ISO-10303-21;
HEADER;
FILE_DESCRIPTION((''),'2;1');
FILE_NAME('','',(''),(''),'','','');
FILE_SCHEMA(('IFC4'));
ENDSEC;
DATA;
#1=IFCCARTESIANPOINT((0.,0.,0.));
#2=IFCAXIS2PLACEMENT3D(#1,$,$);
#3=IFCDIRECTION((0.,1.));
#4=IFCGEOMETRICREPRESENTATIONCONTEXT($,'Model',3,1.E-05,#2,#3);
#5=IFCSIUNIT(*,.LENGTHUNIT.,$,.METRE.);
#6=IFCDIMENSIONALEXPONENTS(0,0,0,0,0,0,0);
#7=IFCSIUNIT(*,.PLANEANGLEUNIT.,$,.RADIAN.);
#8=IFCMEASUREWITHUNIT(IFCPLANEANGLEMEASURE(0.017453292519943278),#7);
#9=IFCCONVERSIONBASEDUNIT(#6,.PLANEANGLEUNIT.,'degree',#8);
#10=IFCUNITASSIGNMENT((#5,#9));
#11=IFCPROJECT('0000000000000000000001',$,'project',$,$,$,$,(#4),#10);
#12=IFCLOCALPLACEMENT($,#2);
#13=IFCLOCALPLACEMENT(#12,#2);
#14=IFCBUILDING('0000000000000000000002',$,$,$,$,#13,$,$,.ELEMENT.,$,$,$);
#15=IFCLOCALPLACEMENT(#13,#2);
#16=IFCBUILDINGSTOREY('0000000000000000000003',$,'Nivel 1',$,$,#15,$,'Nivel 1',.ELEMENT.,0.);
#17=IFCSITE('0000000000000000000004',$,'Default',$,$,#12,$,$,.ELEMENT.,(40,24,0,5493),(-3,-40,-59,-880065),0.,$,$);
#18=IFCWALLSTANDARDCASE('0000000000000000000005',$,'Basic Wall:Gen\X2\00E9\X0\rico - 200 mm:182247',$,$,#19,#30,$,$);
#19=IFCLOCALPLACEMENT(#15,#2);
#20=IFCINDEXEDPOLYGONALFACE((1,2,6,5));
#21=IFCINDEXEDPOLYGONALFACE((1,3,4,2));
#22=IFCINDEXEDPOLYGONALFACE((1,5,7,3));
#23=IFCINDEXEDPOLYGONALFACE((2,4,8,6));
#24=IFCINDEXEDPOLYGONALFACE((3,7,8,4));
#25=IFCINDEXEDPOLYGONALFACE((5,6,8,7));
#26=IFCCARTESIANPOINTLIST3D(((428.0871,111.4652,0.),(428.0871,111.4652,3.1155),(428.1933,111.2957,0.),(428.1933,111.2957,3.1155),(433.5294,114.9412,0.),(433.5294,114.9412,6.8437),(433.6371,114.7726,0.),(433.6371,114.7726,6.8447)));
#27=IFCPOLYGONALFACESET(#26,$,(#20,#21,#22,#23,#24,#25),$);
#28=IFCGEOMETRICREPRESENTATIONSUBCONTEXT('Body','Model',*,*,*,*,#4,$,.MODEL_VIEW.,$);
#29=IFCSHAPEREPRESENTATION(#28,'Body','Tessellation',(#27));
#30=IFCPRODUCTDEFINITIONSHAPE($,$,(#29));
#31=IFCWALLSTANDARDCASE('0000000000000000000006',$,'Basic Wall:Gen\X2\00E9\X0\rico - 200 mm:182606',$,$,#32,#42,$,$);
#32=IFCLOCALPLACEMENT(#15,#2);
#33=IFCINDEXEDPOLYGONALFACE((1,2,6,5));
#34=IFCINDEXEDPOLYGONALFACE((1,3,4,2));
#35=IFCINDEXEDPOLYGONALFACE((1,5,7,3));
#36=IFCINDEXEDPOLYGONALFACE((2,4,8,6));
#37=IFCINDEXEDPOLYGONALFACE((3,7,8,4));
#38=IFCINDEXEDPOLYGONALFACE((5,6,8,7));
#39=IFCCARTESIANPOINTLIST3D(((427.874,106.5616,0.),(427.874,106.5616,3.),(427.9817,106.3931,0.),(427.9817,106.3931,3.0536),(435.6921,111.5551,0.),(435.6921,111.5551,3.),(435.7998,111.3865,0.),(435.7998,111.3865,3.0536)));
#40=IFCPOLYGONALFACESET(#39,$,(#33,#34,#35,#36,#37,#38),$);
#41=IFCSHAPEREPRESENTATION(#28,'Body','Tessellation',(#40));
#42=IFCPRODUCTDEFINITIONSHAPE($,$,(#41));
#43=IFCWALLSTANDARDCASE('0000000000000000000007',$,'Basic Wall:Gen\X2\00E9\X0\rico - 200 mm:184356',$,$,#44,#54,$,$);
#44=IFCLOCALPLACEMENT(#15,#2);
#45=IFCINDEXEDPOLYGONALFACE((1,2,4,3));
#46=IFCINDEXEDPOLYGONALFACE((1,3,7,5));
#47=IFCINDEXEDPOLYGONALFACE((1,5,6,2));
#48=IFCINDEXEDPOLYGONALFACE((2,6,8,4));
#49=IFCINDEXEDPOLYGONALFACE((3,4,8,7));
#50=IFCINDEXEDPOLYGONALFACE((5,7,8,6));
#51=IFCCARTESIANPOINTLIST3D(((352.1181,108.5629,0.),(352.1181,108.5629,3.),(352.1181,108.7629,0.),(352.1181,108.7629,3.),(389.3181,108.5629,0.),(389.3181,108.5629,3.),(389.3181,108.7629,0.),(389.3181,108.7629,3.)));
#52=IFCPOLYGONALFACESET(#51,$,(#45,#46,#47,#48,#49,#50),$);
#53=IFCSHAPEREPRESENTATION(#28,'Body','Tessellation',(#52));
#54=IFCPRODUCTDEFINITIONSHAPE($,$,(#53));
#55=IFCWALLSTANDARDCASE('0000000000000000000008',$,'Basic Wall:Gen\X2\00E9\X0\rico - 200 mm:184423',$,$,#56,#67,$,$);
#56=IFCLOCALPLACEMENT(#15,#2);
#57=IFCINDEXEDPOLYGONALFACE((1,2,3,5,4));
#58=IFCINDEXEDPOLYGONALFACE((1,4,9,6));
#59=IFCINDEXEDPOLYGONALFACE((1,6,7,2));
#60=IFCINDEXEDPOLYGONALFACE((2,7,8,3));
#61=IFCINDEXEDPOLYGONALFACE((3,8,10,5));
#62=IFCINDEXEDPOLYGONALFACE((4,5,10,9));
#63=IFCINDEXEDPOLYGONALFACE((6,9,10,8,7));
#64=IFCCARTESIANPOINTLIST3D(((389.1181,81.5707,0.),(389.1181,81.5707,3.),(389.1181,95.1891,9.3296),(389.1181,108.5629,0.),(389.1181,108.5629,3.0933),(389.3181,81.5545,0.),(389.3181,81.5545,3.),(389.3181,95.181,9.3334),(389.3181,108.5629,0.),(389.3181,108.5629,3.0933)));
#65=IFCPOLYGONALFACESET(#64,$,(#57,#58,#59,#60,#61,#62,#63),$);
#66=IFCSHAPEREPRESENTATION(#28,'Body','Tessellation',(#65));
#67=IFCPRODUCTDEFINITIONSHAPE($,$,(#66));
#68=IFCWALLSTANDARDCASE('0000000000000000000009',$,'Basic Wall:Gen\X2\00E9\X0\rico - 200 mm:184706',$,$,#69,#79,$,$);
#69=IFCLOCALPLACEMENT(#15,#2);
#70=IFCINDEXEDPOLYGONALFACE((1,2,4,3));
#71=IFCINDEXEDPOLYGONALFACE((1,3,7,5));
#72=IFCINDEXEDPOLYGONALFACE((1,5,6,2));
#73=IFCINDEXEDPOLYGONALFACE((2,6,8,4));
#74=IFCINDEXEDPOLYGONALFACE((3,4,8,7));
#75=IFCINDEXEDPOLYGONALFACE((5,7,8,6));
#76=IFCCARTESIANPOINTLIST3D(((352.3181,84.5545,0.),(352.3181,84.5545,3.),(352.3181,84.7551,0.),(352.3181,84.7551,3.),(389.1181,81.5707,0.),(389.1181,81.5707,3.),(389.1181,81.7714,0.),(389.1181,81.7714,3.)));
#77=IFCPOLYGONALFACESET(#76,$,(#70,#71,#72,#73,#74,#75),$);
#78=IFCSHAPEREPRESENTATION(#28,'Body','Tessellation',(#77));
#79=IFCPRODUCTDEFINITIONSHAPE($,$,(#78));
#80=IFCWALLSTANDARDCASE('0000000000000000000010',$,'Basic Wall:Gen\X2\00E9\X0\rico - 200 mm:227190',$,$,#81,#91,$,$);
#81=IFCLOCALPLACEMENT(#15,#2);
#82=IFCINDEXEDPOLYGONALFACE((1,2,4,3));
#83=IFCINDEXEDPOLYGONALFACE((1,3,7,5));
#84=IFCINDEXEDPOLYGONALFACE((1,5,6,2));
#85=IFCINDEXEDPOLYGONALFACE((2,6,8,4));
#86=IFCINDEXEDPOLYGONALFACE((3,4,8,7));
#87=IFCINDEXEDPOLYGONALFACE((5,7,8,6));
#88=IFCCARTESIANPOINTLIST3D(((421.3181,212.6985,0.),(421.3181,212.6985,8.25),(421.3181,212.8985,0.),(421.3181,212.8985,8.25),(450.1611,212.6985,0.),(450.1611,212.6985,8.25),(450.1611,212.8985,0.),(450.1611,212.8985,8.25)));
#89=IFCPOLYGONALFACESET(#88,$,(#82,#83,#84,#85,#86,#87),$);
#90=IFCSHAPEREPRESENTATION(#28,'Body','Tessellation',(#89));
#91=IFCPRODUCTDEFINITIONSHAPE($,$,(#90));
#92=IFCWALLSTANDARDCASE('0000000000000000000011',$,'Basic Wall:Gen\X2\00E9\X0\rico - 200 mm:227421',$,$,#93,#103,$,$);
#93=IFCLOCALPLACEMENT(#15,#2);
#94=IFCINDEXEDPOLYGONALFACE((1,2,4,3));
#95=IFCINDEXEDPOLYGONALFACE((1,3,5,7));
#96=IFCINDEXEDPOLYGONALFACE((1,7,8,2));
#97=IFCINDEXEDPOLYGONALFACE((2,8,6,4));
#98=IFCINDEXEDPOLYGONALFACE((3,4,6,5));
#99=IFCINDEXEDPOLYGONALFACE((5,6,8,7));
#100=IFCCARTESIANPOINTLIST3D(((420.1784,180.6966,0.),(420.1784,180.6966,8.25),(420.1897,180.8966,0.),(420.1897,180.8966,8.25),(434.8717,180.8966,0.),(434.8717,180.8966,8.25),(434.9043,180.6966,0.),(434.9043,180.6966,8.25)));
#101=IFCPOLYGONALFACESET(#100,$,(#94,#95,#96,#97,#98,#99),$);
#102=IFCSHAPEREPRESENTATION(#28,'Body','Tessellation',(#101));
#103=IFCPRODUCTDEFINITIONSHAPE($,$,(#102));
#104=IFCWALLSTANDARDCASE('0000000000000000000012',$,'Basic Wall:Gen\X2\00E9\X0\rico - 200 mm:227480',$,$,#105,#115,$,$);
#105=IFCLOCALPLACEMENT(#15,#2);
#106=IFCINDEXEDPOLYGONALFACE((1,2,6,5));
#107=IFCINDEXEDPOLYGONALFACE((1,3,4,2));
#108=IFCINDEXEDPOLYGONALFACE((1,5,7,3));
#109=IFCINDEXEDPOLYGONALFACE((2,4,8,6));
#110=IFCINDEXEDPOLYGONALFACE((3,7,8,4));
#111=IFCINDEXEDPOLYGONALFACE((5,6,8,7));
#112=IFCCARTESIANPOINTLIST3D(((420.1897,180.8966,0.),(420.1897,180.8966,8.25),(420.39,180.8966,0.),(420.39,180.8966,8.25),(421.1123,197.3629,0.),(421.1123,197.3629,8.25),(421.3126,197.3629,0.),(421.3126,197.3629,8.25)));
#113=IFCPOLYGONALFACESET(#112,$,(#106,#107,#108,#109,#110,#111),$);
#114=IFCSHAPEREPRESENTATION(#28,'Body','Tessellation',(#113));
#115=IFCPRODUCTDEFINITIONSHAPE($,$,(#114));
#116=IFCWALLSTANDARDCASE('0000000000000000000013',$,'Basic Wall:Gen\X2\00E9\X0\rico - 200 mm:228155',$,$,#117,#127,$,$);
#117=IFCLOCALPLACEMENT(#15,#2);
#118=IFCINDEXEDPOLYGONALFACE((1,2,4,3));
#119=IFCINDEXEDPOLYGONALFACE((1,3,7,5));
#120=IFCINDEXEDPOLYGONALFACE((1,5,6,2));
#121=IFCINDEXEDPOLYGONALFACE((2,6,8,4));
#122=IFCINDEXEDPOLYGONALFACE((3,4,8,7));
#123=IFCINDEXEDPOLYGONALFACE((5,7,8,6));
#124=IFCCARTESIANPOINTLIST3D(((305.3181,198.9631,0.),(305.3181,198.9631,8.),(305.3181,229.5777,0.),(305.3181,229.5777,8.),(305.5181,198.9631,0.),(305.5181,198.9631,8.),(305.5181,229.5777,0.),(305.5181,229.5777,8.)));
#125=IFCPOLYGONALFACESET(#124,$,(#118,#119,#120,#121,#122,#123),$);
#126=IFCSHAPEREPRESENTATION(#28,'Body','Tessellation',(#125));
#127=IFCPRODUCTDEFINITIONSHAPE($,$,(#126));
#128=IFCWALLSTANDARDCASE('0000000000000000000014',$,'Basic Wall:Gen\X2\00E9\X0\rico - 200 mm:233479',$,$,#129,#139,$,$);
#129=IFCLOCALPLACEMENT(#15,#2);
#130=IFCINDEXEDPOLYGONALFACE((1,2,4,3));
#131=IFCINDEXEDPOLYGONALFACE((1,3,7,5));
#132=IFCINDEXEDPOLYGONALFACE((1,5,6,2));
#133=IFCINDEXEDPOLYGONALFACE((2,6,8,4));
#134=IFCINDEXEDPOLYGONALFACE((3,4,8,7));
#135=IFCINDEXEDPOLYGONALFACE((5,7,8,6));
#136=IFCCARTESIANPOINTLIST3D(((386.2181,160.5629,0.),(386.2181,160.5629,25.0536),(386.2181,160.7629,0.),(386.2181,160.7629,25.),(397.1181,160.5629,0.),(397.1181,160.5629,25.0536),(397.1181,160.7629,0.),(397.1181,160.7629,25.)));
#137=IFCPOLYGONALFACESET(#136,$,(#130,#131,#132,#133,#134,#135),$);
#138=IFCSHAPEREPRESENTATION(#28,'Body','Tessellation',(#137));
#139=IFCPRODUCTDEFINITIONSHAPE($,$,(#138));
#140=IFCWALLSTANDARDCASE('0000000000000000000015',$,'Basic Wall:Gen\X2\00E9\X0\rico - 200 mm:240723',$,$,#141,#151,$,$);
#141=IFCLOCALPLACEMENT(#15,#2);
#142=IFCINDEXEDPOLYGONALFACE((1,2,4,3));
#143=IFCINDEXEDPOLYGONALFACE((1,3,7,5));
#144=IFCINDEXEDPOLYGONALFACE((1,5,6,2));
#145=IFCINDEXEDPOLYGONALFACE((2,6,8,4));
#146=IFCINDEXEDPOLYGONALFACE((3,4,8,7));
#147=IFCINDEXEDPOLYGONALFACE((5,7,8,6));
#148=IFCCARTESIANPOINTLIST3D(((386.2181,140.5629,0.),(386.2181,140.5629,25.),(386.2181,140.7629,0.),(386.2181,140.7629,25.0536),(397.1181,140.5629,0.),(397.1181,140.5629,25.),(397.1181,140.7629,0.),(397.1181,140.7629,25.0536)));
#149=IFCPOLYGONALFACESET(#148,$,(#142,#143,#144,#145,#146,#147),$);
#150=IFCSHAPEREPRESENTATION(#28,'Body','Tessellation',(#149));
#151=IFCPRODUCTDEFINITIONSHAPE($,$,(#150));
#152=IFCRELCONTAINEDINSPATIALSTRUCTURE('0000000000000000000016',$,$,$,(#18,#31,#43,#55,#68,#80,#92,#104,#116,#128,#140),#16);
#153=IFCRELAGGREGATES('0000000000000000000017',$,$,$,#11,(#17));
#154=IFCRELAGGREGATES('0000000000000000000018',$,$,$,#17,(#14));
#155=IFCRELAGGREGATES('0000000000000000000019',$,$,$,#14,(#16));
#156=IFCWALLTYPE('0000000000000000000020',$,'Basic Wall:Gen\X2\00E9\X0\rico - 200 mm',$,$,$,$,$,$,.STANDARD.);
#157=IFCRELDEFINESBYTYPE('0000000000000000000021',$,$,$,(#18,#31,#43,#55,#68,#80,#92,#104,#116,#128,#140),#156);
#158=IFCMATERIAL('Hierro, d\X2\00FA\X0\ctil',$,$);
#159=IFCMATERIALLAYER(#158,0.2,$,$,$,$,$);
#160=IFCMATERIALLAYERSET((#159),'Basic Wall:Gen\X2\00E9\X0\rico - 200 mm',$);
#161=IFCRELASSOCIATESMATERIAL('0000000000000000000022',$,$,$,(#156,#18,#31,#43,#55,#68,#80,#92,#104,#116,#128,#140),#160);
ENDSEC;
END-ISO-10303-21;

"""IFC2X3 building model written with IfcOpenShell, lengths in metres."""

from ifc_helpers import new_model, entity, si_unit, converted_unit, direction, frame, frame_2d, origin, place, context, subcontext, project, spatial, polyline, rectangle, outline, extrude, clip, bounded_halfspace, material, layer, layer_set, layer_usage, type_object, element, save


model = new_model("IFC2X3")

# Units and contexts
model_context = context("Model", 3, precision=1e-05, world=origin(), true_north=direction((0.0, 1.0)))
body_context = subcontext(model_context, "Body", "Model", "MODEL_VIEW")
ifc_project = project(units=[si_unit("LENGTHUNIT", "METRE"), converted_unit("PLANEANGLEUNIT", "degree", entity("IfcPlaneAngleMeasure", 0.017453292519943278), si_unit("PLANEANGLEUNIT", "RADIAN"), dimensions=[0, 0, 0, 0, 0, 0, 0])], contexts=[model_context])

# Site, building, storey
site_placement = place(None, origin())
site = spatial("IfcSite", under=ifc_project, at=site_placement, Name="Default", CompositionType="ELEMENT", RefLatitude=(40, 24, 0, 5493), RefLongitude=(-3, -40, -59, -880065), RefElevation=0.0)
building_placement = place(site_placement, origin())
building = spatial("IfcBuilding", under=site, at=building_placement, CompositionType="ELEMENT")
storey_placement = place(building_placement, origin())
storey = spatial("IfcBuildingStorey", under=building, at=storey_placement, Name="Nivel 1", LongName="Nivel 1", CompositionType="ELEMENT", Elevation=0.0)

# Shared definitions
ifc_material = material(Name="Hierro, dúctil")
ifc_layer = layer(ifc_material, 0.2)
ifc_layer_set = layer_set([ifc_layer], Name="Basic Wall:Genérico - 200 mm")
wall_type = type_object("IfcWallType", Name="Basic Wall:Genérico - 200 mm", PredefinedType="STANDARD", material=ifc_layer_set)

# Walls
ifc_layer_usage_1 = layer_usage(ifc_layer_set, "AXIS2", "NEGATIVE", 0.1)
wall_1_placement = place(storey_placement, frame((428.1395, 111.38, 0.0), z_axis=(0.0, 0.0, 1.0), x_axis=(0.842768, 0.538277, 0.0)))
element("IfcWallStandardCase", 1, at=wall_1_placement, inside=storey, type_object=wall_type, material=ifc_layer_usage_1, Name="Basic Wall:Genérico - 200 mm:182247", context=body_context, shape_type="Clipping", body=[
    clip(extrude(outline(polyline([(6.4594, -0.1), (6.4594, 0.1), (0.0017, 0.1), (0.0, -0.1), (6.4594, -0.1)])), origin(), (0.0, 0.0, 1.0), 6.8447), bounded_halfspace(frame((0.0, -0.1, 3.1155), z_axis=(-0.499981, 0.004335, 0.866025), x_axis=(-0.008669, -0.999962, 0.0)), False, frame((0.0, -0.1, 3.1155)), polyline([(0.0, 0.0), (6.4594, 0.0), (6.4594, 0.2), (0.0017, 0.2), (0.0, 0.0)]))),
])
ifc_layer_usage_2 = layer_usage(ifc_layer_set, "AXIS2", "NEGATIVE", 0.1)
wall_2_placement = place(storey_placement, frame((427.9279, 106.4774, 0.0), z_axis=(0.0, 0.0, 1.0), x_axis=(0.842768, 0.538277, 0.0)))
element("IfcWallStandardCase", 2, at=wall_2_placement, inside=storey, type_object=wall_type, material=ifc_layer_usage_2, Name="Basic Wall:Genérico - 200 mm:182606", context=body_context, shape_type="Clipping", body=[
    clip(extrude(rectangle(XDim=9.2767, YDim=0.2, at=frame_2d((4.6383, 0.0), x_axis=(-1.0, 0.0))), origin(), (0.0, 0.0, 1.0), 3.0536), bounded_halfspace(frame((0.0, -0.1, 3.0536), z_axis=(0.0, 0.258819, 0.965926), x_axis=(-1.0, 0.0, 0.0)), False, frame((0.0, -0.1, 3.0536)), polyline([(0.0, 0.0), (9.2767, 0.0), (9.2767, 0.2), (0.0, 0.2), (0.0, 0.0)]))),
])
ifc_layer_usage_3 = layer_usage(ifc_layer_set, "AXIS2", "NEGATIVE", 0.1)
wall_3_placement = place(storey_placement, frame((352.1181, 108.6629, 0.0)))
element("IfcWallStandardCase", 3, at=wall_3_placement, inside=storey, type_object=wall_type, material=ifc_layer_usage_3, Name="Basic Wall:Genérico - 200 mm:184356", context=body_context, shape_type="SweptSolid", body=[
    extrude(rectangle(XDim=37.2, YDim=0.2, at=frame_2d((18.6, 0.0), x_axis=(-1.0, 0.0))), origin(), (0.0, 0.0, 1.0), 3.0),
])
ifc_layer_usage_4 = layer_usage(ifc_layer_set, "AXIS2", "NEGATIVE", 0.1)
wall_4_placement = place(storey_placement, frame((389.2181, 108.5629, 0.0), z_axis=(0.0, 0.0, 1.0), x_axis=(0.0, -1.0, 0.0)))
element("IfcWallStandardCase", 4, at=wall_4_placement, inside=storey, type_object=wall_type, material=ifc_layer_usage_4, Name="Basic Wall:Genérico - 200 mm:184423", context=body_context, shape_type="Clipping", body=[
    clip(clip(extrude(outline(polyline([(26.9922, -0.1), (27.0084, 0.1), (0.0, 0.1), (0.0, -0.1), (26.7916, -0.1), (26.9922, -0.1)])), origin(), (0.0, 0.0, 1.0), 9.3334), bounded_halfspace(frame((13.3738, -0.1, 9.3296), z_axis=(0.421236, -0.034154, 0.906308), x_axis=(0.080816, 0.996729, 0.0)), False, frame((13.3738, -0.1, 9.3296)), polyline([(0.0, 0.0), (13.6184, 0.0), (13.6346, 0.2), (0.0081, 0.2), (0.0, 0.0)]))), bounded_halfspace(frame((0.0, -0.1, 3.0933), z_axis=(-0.422618, 0.0, 0.906308), x_axis=(0.0, -1.0, 0.0)), False, frame((0.0, -0.1, 3.0933)), polyline([(0.0, 0.0), (13.3738, 0.0), (13.3819, 0.2), (0.0, 0.2), (0.0, 0.0)]))),
])
ifc_layer_usage_5 = layer_usage(ifc_layer_set, "AXIS2", "NEGATIVE", 0.1)
wall_5_placement = place(storey_placement, frame((352.31, 84.6555, 0.0), z_axis=(0.0, 0.0, 1.0), x_axis=(0.996729, -0.080816, 0.0)))
element("IfcWallStandardCase", 5, at=wall_5_placement, inside=storey, type_object=wall_type, material=ifc_layer_usage_5, Name="Basic Wall:Genérico - 200 mm:184706", context=body_context, shape_type="SweptSolid", body=[
    extrude(outline(polyline([(36.937, -0.1), (36.9208, 0.1), (0.0, 0.1), (0.0162, -0.1), (36.937, -0.1)])), origin(), (0.0, 0.0, 1.0), 3.0),
])
ifc_layer_usage_6 = layer_usage(ifc_layer_set, "AXIS2", "NEGATIVE", 0.1)
wall_6_placement = place(storey_placement, frame((421.3181, 212.7985, 0.0)))
element("IfcWallStandardCase", 6, at=wall_6_placement, inside=storey, type_object=wall_type, material=ifc_layer_usage_6, Name="Basic Wall:Genérico - 200 mm:227190", context=body_context, shape_type="Clipping", body=[
    clip(extrude(rectangle(XDim=28.843, YDim=0.2, at=frame_2d((14.4215, 0.0), x_axis=(-1.0, 0.0))), origin(), (0.0, 0.0, 1.0), 8.25), bounded_halfspace(frame((0.0, -0.1, 8.25)), False, frame((0.0, -0.1, 8.25)), polyline([(0.0, 0.0), (28.643, 0.0), (28.843, 0.0), (28.843, 0.2), (0.0, 0.2), (0.0, 0.0)]))),
])
ifc_layer_usage_7 = layer_usage(ifc_layer_set, "AXIS2", "NEGATIVE", 0.1)
wall_7_placement = place(storey_placement, frame((434.9043, 180.7966, 0.0), z_axis=(0.0, 0.0, 1.0), x_axis=(-1.0, 0.0, 0.0)))
element("IfcWallStandardCase", 7, at=wall_7_placement, inside=storey, type_object=wall_type, material=ifc_layer_usage_7, Name="Basic Wall:Genérico - 200 mm:227421", context=body_context, shape_type="Clipping", body=[
    clip(extrude(outline(polyline([(14.7146, -0.1), (14.7258, 0.1), (0.0, 0.1), (0.0326, -0.1), (14.5143, -0.1), (14.7146, -0.1)])), origin(), (0.0, 0.0, 1.0), 8.25), bounded_halfspace(frame((0.0326, -0.1, 8.25), z_axis=(0.0, 0.0, 1.0), x_axis=(-1.0, 0.0, 0.0)), False, frame((0.0326, -0.1, 8.25)), polyline([(0.0, 0.0), (14.4818, 0.0), (14.6821, 0.0), (14.6933, 0.2), (-0.0326, 0.2), (0.0, 0.0)]))),
])
ifc_layer_usage_8 = layer_usage(ifc_layer_set, "AXIS2", "NEGATIVE", 0.1)
wall_8_placement = place(storey_placement, frame((420.2895, 180.891, 0.0), z_axis=(0.0, 0.0, 1.0), x_axis=(0.055945, 0.998434, 0.0)))
element("IfcWallStandardCase", 8, at=wall_8_placement, inside=storey, type_object=wall_type, material=ifc_layer_usage_8, Name="Basic Wall:Genérico - 200 mm:227480", context=body_context, shape_type="Clipping", body=[
    clip(extrude(outline(polyline([(16.5034, -0.1), (16.4925, 0.0942), (16.4922, 0.1), (0.0, 0.1), (0.0112, -0.1), (16.5034, -0.1)])), origin(), (0.0, 0.0, 1.0), 8.25), bounded_halfspace(frame((0.0112, -0.1, 8.25), z_axis=(0.0, 0.0, 1.0), x_axis=(0.055945, -0.998434, 0.0)), False, frame((0.0112, -0.1, 8.25)), polyline([(0.0, 0.0), (16.4922, 0.0), (16.481, 0.2), (-0.0112, 0.2), (0.0, 0.0)]))),
])
ifc_layer_usage_9 = layer_usage(ifc_layer_set, "AXIS2", "NEGATIVE", 0.1)
wall_9_placement = place(storey_placement, frame((305.4181, 198.9631, 0.0), z_axis=(0.0, 0.0, 1.0), x_axis=(0.0, 1.0, 0.0)))
element("IfcWallStandardCase", 9, at=wall_9_placement, inside=storey, type_object=wall_type, material=ifc_layer_usage_9, Name="Basic Wall:Genérico - 200 mm:228155", context=body_context, shape_type="SweptSolid", body=[
    extrude(rectangle(XDim=30.6146, YDim=0.2, at=frame_2d((15.3073, 0.0), x_axis=(-1.0, 0.0))), origin(), (0.0, 0.0, 1.0), 8.0),
])
ifc_layer_usage_10 = layer_usage(ifc_layer_set, "AXIS2", "NEGATIVE", 0.1)
wall_10_placement = place(storey_placement, frame((397.1181, 160.6629, 0.0), z_axis=(0.0, 0.0, 1.0), x_axis=(-1.0, 0.0, 0.0)))
element("IfcWallStandardCase", 10, at=wall_10_placement, inside=storey, type_object=wall_type, material=ifc_layer_usage_10, Name="Basic Wall:Genérico - 200 mm:233479", context=body_context, shape_type="Clipping", body=[
    clip(extrude(rectangle(XDim=10.9, YDim=0.2, at=frame_2d((5.45, 0.0), x_axis=(-1.0, 0.0))), origin(), (0.0, 0.0, 1.0), 25.0536), bounded_halfspace(frame((0.0, -0.1, 25.0), z_axis=(0.0, -0.258819, 0.965926), x_axis=(1.0, 0.0, 0.0)), False, frame((0.0, -0.1, 25.0)), polyline([(0.0, 0.0), (10.9, 0.0), (10.9, 0.2), (0.0, 0.2), (0.0, 0.0)]))),
])
ifc_layer_usage_11 = layer_usage(ifc_layer_set, "AXIS2", "NEGATIVE", 0.1)
wall_11_placement = place(storey_placement, frame((397.1181, 140.6629, 0.0), z_axis=(0.0, 0.0, 1.0), x_axis=(-1.0, 0.0, 0.0)))
element("IfcWallStandardCase", 11, at=wall_11_placement, inside=storey, type_object=wall_type, material=ifc_layer_usage_11, Name="Basic Wall:Genérico - 200 mm:240723", context=body_context, shape_type="Clipping", body=[
    clip(extrude(rectangle(XDim=10.9, YDim=0.2, at=frame_2d((5.45, 0.0), x_axis=(-1.0, 0.0))), origin(), (0.0, 0.0, 1.0), 25.0536), bounded_halfspace(frame((0.0, -0.1, 25.0536), z_axis=(0.0, 0.258819, 0.965926), x_axis=(-1.0, 0.0, 0.0)), False, frame((0.0, -0.1, 25.0536)), polyline([(0.0, 0.0), (10.9, 0.0), (10.9, 0.2), (0.0, 0.2), (0.0, 0.0)]))),
])

save(model, "model.ifc")
